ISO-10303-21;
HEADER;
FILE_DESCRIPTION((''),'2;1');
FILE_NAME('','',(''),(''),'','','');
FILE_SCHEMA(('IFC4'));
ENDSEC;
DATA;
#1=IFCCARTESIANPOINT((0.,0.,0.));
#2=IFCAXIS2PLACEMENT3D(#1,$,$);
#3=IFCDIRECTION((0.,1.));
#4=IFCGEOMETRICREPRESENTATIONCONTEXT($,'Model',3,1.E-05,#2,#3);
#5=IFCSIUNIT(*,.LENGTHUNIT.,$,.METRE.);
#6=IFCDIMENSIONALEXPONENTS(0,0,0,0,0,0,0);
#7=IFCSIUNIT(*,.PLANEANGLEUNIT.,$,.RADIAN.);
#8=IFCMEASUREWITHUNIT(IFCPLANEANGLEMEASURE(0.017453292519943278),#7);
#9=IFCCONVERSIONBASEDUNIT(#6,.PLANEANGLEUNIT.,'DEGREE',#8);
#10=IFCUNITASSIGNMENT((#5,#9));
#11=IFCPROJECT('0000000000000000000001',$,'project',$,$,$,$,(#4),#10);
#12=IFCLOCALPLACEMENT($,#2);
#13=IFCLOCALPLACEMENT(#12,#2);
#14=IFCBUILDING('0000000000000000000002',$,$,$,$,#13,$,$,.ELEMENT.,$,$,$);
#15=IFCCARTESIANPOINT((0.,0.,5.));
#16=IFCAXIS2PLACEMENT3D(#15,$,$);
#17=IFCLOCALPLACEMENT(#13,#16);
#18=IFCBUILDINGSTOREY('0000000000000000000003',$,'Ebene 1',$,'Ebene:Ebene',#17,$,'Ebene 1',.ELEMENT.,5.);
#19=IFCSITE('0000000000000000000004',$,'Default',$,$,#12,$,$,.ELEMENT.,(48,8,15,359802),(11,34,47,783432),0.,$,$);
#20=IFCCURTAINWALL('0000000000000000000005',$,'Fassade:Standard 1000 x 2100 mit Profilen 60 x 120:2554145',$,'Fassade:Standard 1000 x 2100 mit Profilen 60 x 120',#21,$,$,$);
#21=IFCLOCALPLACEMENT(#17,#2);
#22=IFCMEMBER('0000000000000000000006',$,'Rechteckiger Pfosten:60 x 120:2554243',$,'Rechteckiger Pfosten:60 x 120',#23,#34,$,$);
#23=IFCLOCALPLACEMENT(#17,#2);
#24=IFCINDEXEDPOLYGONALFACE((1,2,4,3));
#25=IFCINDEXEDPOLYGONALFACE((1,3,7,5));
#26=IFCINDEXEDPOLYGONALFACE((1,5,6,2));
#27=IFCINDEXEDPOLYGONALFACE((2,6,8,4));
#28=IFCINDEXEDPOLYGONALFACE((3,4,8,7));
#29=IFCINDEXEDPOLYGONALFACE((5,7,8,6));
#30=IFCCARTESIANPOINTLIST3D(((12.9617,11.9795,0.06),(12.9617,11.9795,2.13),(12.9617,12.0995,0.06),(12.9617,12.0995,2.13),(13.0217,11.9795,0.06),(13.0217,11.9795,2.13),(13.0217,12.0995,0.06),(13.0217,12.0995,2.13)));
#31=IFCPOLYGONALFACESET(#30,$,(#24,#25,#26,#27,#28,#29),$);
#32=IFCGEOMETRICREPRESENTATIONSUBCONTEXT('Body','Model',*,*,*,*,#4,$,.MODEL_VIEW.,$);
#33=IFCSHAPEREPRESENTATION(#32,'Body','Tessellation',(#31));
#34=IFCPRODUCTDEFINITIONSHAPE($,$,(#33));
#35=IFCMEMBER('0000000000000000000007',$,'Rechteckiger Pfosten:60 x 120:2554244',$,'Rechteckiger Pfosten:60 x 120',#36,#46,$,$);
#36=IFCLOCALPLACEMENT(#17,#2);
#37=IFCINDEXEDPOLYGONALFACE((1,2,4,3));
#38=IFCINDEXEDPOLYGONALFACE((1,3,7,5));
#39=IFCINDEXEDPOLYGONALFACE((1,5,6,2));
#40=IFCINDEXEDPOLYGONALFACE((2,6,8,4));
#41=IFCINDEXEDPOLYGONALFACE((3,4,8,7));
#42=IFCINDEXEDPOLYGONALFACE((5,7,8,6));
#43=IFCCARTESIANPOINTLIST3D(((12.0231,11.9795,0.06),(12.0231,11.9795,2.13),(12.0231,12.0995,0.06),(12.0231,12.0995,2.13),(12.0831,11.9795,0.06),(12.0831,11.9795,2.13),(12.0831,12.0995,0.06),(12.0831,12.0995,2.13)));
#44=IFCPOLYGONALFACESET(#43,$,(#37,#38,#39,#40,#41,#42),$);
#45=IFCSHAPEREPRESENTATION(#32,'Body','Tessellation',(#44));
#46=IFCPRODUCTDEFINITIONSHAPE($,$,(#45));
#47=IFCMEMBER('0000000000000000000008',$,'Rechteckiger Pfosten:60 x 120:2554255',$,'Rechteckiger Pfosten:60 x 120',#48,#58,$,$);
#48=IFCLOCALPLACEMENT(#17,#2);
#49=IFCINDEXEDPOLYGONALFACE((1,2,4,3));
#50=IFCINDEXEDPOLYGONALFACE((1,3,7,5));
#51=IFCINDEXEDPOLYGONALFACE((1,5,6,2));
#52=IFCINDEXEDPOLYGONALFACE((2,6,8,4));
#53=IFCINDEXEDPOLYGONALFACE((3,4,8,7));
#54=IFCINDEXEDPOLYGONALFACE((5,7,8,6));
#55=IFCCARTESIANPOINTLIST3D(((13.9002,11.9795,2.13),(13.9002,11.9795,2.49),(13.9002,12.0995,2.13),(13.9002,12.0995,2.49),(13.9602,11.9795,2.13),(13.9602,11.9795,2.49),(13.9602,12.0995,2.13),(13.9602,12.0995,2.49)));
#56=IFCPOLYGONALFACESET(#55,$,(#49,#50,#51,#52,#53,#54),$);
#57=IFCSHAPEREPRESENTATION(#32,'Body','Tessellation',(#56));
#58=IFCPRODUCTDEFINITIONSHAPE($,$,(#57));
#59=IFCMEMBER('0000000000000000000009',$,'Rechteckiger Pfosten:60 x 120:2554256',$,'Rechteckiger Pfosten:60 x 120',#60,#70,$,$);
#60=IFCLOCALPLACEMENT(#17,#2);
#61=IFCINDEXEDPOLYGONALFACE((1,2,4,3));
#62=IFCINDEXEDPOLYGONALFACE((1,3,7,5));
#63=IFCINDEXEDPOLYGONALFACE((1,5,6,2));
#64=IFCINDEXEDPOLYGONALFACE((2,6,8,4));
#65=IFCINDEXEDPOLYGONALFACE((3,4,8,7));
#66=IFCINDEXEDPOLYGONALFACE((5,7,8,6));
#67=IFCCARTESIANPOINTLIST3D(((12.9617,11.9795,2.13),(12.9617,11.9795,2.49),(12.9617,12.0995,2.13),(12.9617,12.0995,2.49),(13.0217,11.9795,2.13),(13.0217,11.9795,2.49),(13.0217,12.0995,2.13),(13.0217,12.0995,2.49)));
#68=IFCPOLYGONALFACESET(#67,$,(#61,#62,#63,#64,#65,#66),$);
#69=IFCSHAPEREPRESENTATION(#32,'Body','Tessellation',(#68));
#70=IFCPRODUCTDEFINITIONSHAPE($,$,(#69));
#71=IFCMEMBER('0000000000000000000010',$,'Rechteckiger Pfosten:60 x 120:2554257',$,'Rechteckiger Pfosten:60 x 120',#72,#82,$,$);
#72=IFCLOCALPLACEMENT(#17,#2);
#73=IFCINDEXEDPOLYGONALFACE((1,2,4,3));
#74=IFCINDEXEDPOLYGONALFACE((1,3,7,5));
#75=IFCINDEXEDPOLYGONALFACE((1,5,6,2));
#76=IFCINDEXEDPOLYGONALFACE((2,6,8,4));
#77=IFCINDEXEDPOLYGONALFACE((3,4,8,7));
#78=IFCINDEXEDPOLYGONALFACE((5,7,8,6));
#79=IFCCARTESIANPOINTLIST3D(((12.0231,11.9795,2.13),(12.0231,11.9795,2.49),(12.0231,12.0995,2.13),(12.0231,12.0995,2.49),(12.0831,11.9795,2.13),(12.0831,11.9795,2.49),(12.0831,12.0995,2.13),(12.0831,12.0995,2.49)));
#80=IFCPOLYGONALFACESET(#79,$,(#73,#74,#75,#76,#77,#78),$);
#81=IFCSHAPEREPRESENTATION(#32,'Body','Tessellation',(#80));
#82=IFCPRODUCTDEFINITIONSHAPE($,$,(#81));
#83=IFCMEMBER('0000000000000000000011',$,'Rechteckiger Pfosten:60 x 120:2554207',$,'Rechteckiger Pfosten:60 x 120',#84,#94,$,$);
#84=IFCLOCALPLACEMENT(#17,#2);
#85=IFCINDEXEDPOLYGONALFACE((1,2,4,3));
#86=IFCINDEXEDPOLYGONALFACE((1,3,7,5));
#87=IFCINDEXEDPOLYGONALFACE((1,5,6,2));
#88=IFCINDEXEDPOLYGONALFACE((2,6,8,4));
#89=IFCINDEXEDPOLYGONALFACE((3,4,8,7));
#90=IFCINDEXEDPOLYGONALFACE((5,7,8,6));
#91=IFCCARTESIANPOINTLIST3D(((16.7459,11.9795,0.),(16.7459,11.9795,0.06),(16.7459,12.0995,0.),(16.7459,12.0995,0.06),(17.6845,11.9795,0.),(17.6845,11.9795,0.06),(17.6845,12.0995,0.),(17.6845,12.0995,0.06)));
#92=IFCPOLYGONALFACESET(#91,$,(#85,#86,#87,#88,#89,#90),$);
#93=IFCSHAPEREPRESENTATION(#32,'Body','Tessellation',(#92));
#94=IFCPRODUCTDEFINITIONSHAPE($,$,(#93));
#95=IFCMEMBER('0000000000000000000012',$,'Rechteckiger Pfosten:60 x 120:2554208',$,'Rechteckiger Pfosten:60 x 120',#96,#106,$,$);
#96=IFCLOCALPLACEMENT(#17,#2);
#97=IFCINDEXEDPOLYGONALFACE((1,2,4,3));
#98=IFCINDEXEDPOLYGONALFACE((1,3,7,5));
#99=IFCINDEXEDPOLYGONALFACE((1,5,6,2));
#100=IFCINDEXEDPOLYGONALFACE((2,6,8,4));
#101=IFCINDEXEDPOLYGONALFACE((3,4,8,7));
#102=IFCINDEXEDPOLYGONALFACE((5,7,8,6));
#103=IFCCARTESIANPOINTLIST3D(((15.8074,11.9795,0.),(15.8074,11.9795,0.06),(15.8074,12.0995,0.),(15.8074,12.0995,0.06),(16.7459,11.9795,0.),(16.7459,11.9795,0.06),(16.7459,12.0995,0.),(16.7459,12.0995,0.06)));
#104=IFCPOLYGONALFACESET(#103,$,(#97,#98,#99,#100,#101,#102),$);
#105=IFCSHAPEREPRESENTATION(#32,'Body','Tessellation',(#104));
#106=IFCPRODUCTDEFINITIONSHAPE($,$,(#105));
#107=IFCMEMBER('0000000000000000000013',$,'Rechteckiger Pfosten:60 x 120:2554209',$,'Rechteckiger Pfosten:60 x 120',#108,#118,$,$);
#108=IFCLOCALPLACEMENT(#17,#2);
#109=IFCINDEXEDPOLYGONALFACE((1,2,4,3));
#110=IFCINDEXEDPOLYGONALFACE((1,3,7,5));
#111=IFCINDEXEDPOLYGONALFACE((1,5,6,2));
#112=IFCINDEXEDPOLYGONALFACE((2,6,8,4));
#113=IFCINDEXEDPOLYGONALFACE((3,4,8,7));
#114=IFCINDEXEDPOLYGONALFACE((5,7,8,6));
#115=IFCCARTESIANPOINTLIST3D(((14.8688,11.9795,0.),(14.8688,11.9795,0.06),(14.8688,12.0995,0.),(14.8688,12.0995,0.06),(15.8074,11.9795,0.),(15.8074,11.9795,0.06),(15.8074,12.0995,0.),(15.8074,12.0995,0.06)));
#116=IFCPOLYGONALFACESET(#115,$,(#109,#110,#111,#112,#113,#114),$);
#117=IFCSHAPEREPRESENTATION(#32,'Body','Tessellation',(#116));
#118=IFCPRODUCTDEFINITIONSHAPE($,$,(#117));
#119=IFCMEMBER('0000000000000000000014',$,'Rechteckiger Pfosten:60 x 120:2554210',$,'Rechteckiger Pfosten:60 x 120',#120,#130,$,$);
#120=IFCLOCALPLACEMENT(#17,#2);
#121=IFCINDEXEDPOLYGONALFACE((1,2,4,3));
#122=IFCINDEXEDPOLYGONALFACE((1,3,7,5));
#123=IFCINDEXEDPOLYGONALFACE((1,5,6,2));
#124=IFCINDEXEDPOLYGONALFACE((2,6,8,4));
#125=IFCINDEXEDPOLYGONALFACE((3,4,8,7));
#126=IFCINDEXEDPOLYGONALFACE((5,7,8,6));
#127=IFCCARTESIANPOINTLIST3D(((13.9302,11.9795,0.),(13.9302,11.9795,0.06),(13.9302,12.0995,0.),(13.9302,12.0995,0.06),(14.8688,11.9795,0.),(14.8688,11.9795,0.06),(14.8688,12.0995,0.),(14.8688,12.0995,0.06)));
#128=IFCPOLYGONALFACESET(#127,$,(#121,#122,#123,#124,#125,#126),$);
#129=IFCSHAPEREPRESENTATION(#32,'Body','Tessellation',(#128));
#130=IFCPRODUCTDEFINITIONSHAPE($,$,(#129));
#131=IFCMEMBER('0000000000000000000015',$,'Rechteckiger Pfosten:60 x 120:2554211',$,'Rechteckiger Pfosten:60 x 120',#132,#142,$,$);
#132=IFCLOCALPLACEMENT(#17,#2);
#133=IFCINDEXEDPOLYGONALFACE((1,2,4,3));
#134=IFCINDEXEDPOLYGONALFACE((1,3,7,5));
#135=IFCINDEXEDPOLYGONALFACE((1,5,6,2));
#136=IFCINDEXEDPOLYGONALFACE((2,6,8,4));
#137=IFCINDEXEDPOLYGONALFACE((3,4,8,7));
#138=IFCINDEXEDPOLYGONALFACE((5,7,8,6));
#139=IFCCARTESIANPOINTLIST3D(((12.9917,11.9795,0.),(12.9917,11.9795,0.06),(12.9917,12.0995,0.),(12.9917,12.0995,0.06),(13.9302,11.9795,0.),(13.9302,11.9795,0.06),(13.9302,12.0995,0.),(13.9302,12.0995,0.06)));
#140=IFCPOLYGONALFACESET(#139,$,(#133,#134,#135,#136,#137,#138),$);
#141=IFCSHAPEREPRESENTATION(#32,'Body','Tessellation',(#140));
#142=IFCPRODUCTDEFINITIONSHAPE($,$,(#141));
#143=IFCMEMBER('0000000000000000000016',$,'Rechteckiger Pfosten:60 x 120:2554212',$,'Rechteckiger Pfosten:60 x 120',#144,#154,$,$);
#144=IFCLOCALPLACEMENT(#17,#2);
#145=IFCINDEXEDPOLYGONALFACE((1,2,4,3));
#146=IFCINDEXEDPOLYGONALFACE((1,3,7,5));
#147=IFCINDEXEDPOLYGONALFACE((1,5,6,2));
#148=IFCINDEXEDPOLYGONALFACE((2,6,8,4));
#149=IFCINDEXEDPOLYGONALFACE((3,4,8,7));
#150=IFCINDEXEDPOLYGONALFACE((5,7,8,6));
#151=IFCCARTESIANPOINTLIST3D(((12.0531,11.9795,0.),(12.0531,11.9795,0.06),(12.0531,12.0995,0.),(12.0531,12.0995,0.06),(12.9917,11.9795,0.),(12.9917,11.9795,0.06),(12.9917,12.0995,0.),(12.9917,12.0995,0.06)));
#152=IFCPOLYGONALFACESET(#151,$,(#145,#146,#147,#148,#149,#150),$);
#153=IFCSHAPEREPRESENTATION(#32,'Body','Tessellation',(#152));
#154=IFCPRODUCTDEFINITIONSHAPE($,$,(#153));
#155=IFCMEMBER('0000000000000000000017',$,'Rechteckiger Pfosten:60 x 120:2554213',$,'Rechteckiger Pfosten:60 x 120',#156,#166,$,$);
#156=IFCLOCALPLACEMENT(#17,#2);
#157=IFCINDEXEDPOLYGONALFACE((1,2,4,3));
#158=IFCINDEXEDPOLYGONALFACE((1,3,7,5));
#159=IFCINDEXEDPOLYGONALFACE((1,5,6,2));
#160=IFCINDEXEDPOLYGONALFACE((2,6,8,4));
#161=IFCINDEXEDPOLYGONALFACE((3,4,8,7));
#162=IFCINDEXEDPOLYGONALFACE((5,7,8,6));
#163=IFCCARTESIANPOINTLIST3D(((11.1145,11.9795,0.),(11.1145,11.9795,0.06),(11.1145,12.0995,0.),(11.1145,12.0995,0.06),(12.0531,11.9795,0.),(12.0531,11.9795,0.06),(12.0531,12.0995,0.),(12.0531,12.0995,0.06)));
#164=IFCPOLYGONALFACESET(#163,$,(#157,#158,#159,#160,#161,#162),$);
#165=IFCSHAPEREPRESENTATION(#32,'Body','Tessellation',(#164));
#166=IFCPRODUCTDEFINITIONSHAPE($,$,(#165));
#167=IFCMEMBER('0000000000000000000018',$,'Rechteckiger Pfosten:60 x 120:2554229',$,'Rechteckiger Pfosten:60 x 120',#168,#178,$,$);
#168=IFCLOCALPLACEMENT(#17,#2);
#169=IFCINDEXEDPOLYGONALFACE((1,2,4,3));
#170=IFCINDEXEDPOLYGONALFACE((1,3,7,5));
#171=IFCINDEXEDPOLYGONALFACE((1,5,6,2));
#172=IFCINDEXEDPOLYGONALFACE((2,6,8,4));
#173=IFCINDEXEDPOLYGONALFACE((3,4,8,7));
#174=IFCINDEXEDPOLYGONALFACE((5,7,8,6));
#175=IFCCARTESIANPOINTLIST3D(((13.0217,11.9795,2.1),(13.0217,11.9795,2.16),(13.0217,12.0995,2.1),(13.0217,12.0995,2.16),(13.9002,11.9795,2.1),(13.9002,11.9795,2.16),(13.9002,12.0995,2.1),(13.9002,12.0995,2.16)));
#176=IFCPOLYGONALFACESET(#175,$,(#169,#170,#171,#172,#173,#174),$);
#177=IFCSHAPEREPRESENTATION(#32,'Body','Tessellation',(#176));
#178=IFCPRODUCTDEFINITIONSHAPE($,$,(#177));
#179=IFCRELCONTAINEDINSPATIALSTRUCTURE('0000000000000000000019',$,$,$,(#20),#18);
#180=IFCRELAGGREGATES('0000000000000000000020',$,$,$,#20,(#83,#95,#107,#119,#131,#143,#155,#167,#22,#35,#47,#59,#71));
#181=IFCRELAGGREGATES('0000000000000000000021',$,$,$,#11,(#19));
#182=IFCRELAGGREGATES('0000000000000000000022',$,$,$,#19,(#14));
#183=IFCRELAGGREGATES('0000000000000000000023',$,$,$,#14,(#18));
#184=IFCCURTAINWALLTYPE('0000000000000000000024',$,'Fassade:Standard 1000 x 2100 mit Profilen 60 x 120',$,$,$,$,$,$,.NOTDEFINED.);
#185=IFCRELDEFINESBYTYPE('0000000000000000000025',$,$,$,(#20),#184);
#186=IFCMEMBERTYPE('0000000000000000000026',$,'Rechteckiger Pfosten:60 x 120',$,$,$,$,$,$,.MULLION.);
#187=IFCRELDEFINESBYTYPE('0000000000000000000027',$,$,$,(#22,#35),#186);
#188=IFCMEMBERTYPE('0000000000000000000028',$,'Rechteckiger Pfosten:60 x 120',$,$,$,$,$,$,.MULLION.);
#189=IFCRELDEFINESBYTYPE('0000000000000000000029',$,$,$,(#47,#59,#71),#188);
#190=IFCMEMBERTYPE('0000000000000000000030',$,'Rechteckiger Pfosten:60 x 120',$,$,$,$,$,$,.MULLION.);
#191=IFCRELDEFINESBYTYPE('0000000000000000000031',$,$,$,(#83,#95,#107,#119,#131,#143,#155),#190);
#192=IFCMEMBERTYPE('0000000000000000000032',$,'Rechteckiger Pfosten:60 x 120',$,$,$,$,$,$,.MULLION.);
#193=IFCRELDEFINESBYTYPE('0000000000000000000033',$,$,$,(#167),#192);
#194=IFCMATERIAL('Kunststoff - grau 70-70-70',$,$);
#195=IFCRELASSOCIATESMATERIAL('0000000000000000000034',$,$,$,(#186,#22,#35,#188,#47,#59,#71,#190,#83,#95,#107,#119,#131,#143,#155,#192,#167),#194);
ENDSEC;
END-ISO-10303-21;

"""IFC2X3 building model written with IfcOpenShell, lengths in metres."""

from ifc_helpers import new_model, entity, si_unit, converted_unit, direction, frame, frame_2d, origin, origin_2d_with_axis, place, context, subcontext, project, spatial, rectangle, extrude, source, transform, mapped, material, type_object, type_shapes, element, aggregate, save


model = new_model("IFC2X3")

# Units and contexts
model_context = context("Model", 3, precision=1e-05, world=origin(), true_north=direction((0.0, 1.0)))
body_context = subcontext(model_context, "Body", "Model", "MODEL_VIEW")
ifc_project = project(units=[si_unit("LENGTHUNIT", "METRE"), converted_unit("PLANEANGLEUNIT", "DEGREE", entity("IfcPlaneAngleMeasure", 0.017453292519943278), si_unit("PLANEANGLEUNIT", "RADIAN"), dimensions=[0, 0, 0, 0, 0, 0, 0])], contexts=[model_context])

# Site, building, storey
site_placement = place(None, origin())
site = spatial("IfcSite", under=ifc_project, at=site_placement, Name="Default", CompositionType="ELEMENT", RefLatitude=(48, 8, 15, 359802), RefLongitude=(11, 34, 47, 783432), RefElevation=0.0)
building_placement = place(site_placement, origin())
building = spatial("IfcBuilding", under=site, at=building_placement, CompositionType="ELEMENT")
storey_placement = place(building_placement, frame((0.0, 0.0, 5.0)))
storey = spatial("IfcBuildingStorey", under=building, at=storey_placement, Name="Ebene 1", ObjectType="Ebene:Ebene", LongName="Ebene 1", CompositionType="ELEMENT", Elevation=5.0)

# Curtain wall, members
curtain_wall_type = type_object("IfcCurtainWallType", Name="Fassade:Standard 1000 x 2100 mit Profilen 60 x 120", PredefinedType="NOTDEFINED")
ifc_material_1 = material(Name="Kunststoff - grau 70-70-70")
member_type_1 = type_object("IfcMemberType", Name="Rechteckiger Pfosten:60 x 120", PredefinedType="MULLION", material=ifc_material_1)
shared_shape_1 = source(origin(), body_context, "Body", "SweptSolid", [
    extrude(rectangle(XDim=0.06, YDim=0.12, at=origin_2d_with_axis()), frame((0.0, 0.0, -2.07), z_axis=(0.0, 0.0, 1.0), x_axis=(-1.0, 0.0, 0.0)), (0.0, 0.0, 1.0), 2.07),
])
type_shapes(member_type_1, [shared_shape_1])
curtain_wall_1_placement = place(storey_placement, frame((0.0, 0.0, -5.0)))
curtain_wall_1 = element("IfcCurtainWall", 1, at=curtain_wall_1_placement, inside=storey, type_object=curtain_wall_type, Name="Fassade:Standard 1000 x 2100 mit Profilen 60 x 120:2554145", ObjectType="Fassade:Standard 1000 x 2100 mit Profilen 60 x 120")
member_1_placement = place(curtain_wall_1_placement, frame((12.9917, 12.0395, 5.06), z_axis=(0.0, 0.0, -1.0), x_axis=(-1.0, 0.0, 0.0)))
member_1 = element("IfcMember", 2, at=member_1_placement, type_object=member_type_1, material=ifc_material_1, Name="Rechteckiger Pfosten:60 x 120:2554243", ObjectType="Rechteckiger Pfosten:60 x 120", context=body_context, shape_type="MappedRepresentation", body=[
    mapped(shared_shape_1, transform((0.0, 0.0, 0.0), scale=1.0)),
])
member_2_placement = place(curtain_wall_1_placement, frame((12.0531, 12.0395, 5.06), z_axis=(0.0, 0.0, -1.0), x_axis=(-1.0, 0.0, 0.0)))
member_2 = element("IfcMember", 3, at=member_2_placement, type_object=member_type_1, material=ifc_material_1, Name="Rechteckiger Pfosten:60 x 120:2554244", ObjectType="Rechteckiger Pfosten:60 x 120", context=body_context, shape_type="MappedRepresentation", body=[
    mapped(shared_shape_1, transform((0.0, 0.0, 0.0), scale=1.0)),
])
member_type_2 = type_object("IfcMemberType", Name="Rechteckiger Pfosten:60 x 120", PredefinedType="MULLION", material=ifc_material_1)
shared_shape_2 = source(origin(), body_context, "Body", "SweptSolid", [
    extrude(rectangle(XDim=0.06, YDim=0.12, at=frame_2d((0.0, 0.0), x_axis=(1.0, 0.0))), frame((0.0, 0.0, -0.36), z_axis=(0.0, 0.0, 1.0), x_axis=(-1.0, 0.0, 0.0)), (0.0, 0.0, 1.0), 0.36),
])
type_shapes(member_type_2, [shared_shape_2])
member_3_placement = place(curtain_wall_1_placement, frame((13.9302, 12.0395, 7.13), z_axis=(0.0, 0.0, -1.0), x_axis=(-1.0, 0.0, 0.0)))
member_3 = element("IfcMember", 4, at=member_3_placement, type_object=member_type_2, material=ifc_material_1, Name="Rechteckiger Pfosten:60 x 120:2554255", ObjectType="Rechteckiger Pfosten:60 x 120", context=body_context, shape_type="MappedRepresentation", body=[
    mapped(shared_shape_2, transform((0.0, 0.0, 0.0), scale=1.0)),
])
member_4_placement = place(curtain_wall_1_placement, frame((12.9917, 12.0395, 7.13), z_axis=(0.0, 0.0, -1.0), x_axis=(-1.0, 0.0, 0.0)))
member_4 = element("IfcMember", 5, at=member_4_placement, type_object=member_type_2, material=ifc_material_1, Name="Rechteckiger Pfosten:60 x 120:2554256", ObjectType="Rechteckiger Pfosten:60 x 120", context=body_context, shape_type="MappedRepresentation", body=[
    mapped(shared_shape_2, transform((0.0, 0.0, 0.0), scale=1.0)),
])
member_5_placement = place(curtain_wall_1_placement, frame((12.0531, 12.0395, 7.13), z_axis=(0.0, 0.0, -1.0), x_axis=(-1.0, 0.0, 0.0)))
member_5 = element("IfcMember", 6, at=member_5_placement, type_object=member_type_2, material=ifc_material_1, Name="Rechteckiger Pfosten:60 x 120:2554257", ObjectType="Rechteckiger Pfosten:60 x 120", context=body_context, shape_type="MappedRepresentation", body=[
    mapped(shared_shape_2, transform((0.0, 0.0, 0.0), scale=1.0)),
])

# Members
member_type_3 = type_object("IfcMemberType", Name="Rechteckiger Pfosten:60 x 120", PredefinedType="MULLION", material=ifc_material_1)
shared_shape_3 = source(origin(), body_context, "Body", "SweptSolid", [
    extrude(rectangle(XDim=0.06, YDim=0.12, at=origin_2d_with_axis()), frame((-0.03, 0.0, -0.9386), z_axis=(0.0, 0.0, 1.0), x_axis=(-1.0, 0.0, 0.0)), (0.0, 0.0, 1.0), 0.9386),
])
type_shapes(member_type_3, [shared_shape_3])
member_6_placement = place(curtain_wall_1_placement, frame((17.6845, 12.0395, 5.0), z_axis=(1.0, 0.0, 0.0), x_axis=(0.0, 0.0, -1.0)))
member_6 = element("IfcMember", 7, at=member_6_placement, type_object=member_type_3, material=ifc_material_1, Name="Rechteckiger Pfosten:60 x 120:2554207", ObjectType="Rechteckiger Pfosten:60 x 120", context=body_context, shape_type="MappedRepresentation", body=[
    mapped(shared_shape_3, transform((0.0, 0.0, 0.0), scale=1.0)),
])
member_7_placement = place(curtain_wall_1_placement, frame((16.7459, 12.0395, 5.0), z_axis=(1.0, 0.0, 0.0), x_axis=(0.0, 0.0, -1.0)))
member_7 = element("IfcMember", 8, at=member_7_placement, type_object=member_type_3, material=ifc_material_1, Name="Rechteckiger Pfosten:60 x 120:2554208", ObjectType="Rechteckiger Pfosten:60 x 120", context=body_context, shape_type="MappedRepresentation", body=[
    mapped(shared_shape_3, transform((0.0, 0.0, 0.0), scale=1.0)),
])
member_8_placement = place(curtain_wall_1_placement, frame((15.8074, 12.0395, 5.0), z_axis=(1.0, 0.0, 0.0), x_axis=(0.0, 0.0, -1.0)))
member_8 = element("IfcMember", 9, at=member_8_placement, type_object=member_type_3, material=ifc_material_1, Name="Rechteckiger Pfosten:60 x 120:2554209", ObjectType="Rechteckiger Pfosten:60 x 120", context=body_context, shape_type="MappedRepresentation", body=[
    mapped(shared_shape_3, transform((0.0, 0.0, 0.0), scale=1.0)),
])
member_9_placement = place(curtain_wall_1_placement, frame((14.8688, 12.0395, 5.0), z_axis=(1.0, 0.0, 0.0), x_axis=(0.0, 0.0, -1.0)))
member_9 = element("IfcMember", 10, at=member_9_placement, type_object=member_type_3, material=ifc_material_1, Name="Rechteckiger Pfosten:60 x 120:2554210", ObjectType="Rechteckiger Pfosten:60 x 120", context=body_context, shape_type="MappedRepresentation", body=[
    mapped(shared_shape_3, transform((0.0, 0.0, 0.0), scale=1.0)),
])
member_10_placement = place(curtain_wall_1_placement, frame((13.9302, 12.0395, 5.0), z_axis=(1.0, 0.0, 0.0), x_axis=(0.0, 0.0, -1.0)))
member_10 = element("IfcMember", 11, at=member_10_placement, type_object=member_type_3, material=ifc_material_1, Name="Rechteckiger Pfosten:60 x 120:2554211", ObjectType="Rechteckiger Pfosten:60 x 120", context=body_context, shape_type="MappedRepresentation", body=[
    mapped(shared_shape_3, transform((0.0, 0.0, 0.0), scale=1.0)),
])
member_11_placement = place(curtain_wall_1_placement, frame((12.9917, 12.0395, 5.0), z_axis=(1.0, 0.0, 0.0), x_axis=(0.0, 0.0, -1.0)))
member_11 = element("IfcMember", 12, at=member_11_placement, type_object=member_type_3, material=ifc_material_1, Name="Rechteckiger Pfosten:60 x 120:2554212", ObjectType="Rechteckiger Pfosten:60 x 120", context=body_context, shape_type="MappedRepresentation", body=[
    mapped(shared_shape_3, transform((0.0, 0.0, 0.0), scale=1.0)),
])
member_12_placement = place(curtain_wall_1_placement, frame((12.0531, 12.0395, 5.0), z_axis=(1.0, 0.0, 0.0), x_axis=(0.0, 0.0, -1.0)))
member_12 = element("IfcMember", 13, at=member_12_placement, type_object=member_type_3, material=ifc_material_1, Name="Rechteckiger Pfosten:60 x 120:2554213", ObjectType="Rechteckiger Pfosten:60 x 120", context=body_context, shape_type="MappedRepresentation", body=[
    mapped(shared_shape_3, transform((0.0, 0.0, 0.0), scale=1.0)),
])
member_type_4 = type_object("IfcMemberType", Name="Rechteckiger Pfosten:60 x 120", PredefinedType="MULLION", material=ifc_material_1)
shared_shape_4 = source(origin(), body_context, "Body", "SweptSolid", [
    extrude(rectangle(XDim=0.06, YDim=0.12, at=frame_2d((0.0, 0.0), x_axis=(1.0, 0.0))), frame((0.0, 0.0, -0.8786), z_axis=(0.0, 0.0, 1.0), x_axis=(-1.0, 0.0, 0.0)), (0.0, 0.0, 1.0), 0.8786),
])
type_shapes(member_type_4, [shared_shape_4])
member_13_placement = place(curtain_wall_1_placement, frame((13.0217, 12.0395, 7.13), z_axis=(-1.0, 0.0, 0.0), x_axis=(0.0, 0.0, 1.0)))
member_13 = element("IfcMember", 14, at=member_13_placement, type_object=member_type_4, material=ifc_material_1, Name="Rechteckiger Pfosten:60 x 120:2554229", ObjectType="Rechteckiger Pfosten:60 x 120", context=body_context, shape_type="MappedRepresentation", body=[
    mapped(shared_shape_4, transform((0.0, 0.0, 0.0), scale=1.0)),
])

aggregate(curtain_wall_1, [member_6, member_7, member_8, member_9, member_10, member_11, member_12, member_13, member_1, member_2, member_3, member_4, member_5])

save(model, "model.ifc")
